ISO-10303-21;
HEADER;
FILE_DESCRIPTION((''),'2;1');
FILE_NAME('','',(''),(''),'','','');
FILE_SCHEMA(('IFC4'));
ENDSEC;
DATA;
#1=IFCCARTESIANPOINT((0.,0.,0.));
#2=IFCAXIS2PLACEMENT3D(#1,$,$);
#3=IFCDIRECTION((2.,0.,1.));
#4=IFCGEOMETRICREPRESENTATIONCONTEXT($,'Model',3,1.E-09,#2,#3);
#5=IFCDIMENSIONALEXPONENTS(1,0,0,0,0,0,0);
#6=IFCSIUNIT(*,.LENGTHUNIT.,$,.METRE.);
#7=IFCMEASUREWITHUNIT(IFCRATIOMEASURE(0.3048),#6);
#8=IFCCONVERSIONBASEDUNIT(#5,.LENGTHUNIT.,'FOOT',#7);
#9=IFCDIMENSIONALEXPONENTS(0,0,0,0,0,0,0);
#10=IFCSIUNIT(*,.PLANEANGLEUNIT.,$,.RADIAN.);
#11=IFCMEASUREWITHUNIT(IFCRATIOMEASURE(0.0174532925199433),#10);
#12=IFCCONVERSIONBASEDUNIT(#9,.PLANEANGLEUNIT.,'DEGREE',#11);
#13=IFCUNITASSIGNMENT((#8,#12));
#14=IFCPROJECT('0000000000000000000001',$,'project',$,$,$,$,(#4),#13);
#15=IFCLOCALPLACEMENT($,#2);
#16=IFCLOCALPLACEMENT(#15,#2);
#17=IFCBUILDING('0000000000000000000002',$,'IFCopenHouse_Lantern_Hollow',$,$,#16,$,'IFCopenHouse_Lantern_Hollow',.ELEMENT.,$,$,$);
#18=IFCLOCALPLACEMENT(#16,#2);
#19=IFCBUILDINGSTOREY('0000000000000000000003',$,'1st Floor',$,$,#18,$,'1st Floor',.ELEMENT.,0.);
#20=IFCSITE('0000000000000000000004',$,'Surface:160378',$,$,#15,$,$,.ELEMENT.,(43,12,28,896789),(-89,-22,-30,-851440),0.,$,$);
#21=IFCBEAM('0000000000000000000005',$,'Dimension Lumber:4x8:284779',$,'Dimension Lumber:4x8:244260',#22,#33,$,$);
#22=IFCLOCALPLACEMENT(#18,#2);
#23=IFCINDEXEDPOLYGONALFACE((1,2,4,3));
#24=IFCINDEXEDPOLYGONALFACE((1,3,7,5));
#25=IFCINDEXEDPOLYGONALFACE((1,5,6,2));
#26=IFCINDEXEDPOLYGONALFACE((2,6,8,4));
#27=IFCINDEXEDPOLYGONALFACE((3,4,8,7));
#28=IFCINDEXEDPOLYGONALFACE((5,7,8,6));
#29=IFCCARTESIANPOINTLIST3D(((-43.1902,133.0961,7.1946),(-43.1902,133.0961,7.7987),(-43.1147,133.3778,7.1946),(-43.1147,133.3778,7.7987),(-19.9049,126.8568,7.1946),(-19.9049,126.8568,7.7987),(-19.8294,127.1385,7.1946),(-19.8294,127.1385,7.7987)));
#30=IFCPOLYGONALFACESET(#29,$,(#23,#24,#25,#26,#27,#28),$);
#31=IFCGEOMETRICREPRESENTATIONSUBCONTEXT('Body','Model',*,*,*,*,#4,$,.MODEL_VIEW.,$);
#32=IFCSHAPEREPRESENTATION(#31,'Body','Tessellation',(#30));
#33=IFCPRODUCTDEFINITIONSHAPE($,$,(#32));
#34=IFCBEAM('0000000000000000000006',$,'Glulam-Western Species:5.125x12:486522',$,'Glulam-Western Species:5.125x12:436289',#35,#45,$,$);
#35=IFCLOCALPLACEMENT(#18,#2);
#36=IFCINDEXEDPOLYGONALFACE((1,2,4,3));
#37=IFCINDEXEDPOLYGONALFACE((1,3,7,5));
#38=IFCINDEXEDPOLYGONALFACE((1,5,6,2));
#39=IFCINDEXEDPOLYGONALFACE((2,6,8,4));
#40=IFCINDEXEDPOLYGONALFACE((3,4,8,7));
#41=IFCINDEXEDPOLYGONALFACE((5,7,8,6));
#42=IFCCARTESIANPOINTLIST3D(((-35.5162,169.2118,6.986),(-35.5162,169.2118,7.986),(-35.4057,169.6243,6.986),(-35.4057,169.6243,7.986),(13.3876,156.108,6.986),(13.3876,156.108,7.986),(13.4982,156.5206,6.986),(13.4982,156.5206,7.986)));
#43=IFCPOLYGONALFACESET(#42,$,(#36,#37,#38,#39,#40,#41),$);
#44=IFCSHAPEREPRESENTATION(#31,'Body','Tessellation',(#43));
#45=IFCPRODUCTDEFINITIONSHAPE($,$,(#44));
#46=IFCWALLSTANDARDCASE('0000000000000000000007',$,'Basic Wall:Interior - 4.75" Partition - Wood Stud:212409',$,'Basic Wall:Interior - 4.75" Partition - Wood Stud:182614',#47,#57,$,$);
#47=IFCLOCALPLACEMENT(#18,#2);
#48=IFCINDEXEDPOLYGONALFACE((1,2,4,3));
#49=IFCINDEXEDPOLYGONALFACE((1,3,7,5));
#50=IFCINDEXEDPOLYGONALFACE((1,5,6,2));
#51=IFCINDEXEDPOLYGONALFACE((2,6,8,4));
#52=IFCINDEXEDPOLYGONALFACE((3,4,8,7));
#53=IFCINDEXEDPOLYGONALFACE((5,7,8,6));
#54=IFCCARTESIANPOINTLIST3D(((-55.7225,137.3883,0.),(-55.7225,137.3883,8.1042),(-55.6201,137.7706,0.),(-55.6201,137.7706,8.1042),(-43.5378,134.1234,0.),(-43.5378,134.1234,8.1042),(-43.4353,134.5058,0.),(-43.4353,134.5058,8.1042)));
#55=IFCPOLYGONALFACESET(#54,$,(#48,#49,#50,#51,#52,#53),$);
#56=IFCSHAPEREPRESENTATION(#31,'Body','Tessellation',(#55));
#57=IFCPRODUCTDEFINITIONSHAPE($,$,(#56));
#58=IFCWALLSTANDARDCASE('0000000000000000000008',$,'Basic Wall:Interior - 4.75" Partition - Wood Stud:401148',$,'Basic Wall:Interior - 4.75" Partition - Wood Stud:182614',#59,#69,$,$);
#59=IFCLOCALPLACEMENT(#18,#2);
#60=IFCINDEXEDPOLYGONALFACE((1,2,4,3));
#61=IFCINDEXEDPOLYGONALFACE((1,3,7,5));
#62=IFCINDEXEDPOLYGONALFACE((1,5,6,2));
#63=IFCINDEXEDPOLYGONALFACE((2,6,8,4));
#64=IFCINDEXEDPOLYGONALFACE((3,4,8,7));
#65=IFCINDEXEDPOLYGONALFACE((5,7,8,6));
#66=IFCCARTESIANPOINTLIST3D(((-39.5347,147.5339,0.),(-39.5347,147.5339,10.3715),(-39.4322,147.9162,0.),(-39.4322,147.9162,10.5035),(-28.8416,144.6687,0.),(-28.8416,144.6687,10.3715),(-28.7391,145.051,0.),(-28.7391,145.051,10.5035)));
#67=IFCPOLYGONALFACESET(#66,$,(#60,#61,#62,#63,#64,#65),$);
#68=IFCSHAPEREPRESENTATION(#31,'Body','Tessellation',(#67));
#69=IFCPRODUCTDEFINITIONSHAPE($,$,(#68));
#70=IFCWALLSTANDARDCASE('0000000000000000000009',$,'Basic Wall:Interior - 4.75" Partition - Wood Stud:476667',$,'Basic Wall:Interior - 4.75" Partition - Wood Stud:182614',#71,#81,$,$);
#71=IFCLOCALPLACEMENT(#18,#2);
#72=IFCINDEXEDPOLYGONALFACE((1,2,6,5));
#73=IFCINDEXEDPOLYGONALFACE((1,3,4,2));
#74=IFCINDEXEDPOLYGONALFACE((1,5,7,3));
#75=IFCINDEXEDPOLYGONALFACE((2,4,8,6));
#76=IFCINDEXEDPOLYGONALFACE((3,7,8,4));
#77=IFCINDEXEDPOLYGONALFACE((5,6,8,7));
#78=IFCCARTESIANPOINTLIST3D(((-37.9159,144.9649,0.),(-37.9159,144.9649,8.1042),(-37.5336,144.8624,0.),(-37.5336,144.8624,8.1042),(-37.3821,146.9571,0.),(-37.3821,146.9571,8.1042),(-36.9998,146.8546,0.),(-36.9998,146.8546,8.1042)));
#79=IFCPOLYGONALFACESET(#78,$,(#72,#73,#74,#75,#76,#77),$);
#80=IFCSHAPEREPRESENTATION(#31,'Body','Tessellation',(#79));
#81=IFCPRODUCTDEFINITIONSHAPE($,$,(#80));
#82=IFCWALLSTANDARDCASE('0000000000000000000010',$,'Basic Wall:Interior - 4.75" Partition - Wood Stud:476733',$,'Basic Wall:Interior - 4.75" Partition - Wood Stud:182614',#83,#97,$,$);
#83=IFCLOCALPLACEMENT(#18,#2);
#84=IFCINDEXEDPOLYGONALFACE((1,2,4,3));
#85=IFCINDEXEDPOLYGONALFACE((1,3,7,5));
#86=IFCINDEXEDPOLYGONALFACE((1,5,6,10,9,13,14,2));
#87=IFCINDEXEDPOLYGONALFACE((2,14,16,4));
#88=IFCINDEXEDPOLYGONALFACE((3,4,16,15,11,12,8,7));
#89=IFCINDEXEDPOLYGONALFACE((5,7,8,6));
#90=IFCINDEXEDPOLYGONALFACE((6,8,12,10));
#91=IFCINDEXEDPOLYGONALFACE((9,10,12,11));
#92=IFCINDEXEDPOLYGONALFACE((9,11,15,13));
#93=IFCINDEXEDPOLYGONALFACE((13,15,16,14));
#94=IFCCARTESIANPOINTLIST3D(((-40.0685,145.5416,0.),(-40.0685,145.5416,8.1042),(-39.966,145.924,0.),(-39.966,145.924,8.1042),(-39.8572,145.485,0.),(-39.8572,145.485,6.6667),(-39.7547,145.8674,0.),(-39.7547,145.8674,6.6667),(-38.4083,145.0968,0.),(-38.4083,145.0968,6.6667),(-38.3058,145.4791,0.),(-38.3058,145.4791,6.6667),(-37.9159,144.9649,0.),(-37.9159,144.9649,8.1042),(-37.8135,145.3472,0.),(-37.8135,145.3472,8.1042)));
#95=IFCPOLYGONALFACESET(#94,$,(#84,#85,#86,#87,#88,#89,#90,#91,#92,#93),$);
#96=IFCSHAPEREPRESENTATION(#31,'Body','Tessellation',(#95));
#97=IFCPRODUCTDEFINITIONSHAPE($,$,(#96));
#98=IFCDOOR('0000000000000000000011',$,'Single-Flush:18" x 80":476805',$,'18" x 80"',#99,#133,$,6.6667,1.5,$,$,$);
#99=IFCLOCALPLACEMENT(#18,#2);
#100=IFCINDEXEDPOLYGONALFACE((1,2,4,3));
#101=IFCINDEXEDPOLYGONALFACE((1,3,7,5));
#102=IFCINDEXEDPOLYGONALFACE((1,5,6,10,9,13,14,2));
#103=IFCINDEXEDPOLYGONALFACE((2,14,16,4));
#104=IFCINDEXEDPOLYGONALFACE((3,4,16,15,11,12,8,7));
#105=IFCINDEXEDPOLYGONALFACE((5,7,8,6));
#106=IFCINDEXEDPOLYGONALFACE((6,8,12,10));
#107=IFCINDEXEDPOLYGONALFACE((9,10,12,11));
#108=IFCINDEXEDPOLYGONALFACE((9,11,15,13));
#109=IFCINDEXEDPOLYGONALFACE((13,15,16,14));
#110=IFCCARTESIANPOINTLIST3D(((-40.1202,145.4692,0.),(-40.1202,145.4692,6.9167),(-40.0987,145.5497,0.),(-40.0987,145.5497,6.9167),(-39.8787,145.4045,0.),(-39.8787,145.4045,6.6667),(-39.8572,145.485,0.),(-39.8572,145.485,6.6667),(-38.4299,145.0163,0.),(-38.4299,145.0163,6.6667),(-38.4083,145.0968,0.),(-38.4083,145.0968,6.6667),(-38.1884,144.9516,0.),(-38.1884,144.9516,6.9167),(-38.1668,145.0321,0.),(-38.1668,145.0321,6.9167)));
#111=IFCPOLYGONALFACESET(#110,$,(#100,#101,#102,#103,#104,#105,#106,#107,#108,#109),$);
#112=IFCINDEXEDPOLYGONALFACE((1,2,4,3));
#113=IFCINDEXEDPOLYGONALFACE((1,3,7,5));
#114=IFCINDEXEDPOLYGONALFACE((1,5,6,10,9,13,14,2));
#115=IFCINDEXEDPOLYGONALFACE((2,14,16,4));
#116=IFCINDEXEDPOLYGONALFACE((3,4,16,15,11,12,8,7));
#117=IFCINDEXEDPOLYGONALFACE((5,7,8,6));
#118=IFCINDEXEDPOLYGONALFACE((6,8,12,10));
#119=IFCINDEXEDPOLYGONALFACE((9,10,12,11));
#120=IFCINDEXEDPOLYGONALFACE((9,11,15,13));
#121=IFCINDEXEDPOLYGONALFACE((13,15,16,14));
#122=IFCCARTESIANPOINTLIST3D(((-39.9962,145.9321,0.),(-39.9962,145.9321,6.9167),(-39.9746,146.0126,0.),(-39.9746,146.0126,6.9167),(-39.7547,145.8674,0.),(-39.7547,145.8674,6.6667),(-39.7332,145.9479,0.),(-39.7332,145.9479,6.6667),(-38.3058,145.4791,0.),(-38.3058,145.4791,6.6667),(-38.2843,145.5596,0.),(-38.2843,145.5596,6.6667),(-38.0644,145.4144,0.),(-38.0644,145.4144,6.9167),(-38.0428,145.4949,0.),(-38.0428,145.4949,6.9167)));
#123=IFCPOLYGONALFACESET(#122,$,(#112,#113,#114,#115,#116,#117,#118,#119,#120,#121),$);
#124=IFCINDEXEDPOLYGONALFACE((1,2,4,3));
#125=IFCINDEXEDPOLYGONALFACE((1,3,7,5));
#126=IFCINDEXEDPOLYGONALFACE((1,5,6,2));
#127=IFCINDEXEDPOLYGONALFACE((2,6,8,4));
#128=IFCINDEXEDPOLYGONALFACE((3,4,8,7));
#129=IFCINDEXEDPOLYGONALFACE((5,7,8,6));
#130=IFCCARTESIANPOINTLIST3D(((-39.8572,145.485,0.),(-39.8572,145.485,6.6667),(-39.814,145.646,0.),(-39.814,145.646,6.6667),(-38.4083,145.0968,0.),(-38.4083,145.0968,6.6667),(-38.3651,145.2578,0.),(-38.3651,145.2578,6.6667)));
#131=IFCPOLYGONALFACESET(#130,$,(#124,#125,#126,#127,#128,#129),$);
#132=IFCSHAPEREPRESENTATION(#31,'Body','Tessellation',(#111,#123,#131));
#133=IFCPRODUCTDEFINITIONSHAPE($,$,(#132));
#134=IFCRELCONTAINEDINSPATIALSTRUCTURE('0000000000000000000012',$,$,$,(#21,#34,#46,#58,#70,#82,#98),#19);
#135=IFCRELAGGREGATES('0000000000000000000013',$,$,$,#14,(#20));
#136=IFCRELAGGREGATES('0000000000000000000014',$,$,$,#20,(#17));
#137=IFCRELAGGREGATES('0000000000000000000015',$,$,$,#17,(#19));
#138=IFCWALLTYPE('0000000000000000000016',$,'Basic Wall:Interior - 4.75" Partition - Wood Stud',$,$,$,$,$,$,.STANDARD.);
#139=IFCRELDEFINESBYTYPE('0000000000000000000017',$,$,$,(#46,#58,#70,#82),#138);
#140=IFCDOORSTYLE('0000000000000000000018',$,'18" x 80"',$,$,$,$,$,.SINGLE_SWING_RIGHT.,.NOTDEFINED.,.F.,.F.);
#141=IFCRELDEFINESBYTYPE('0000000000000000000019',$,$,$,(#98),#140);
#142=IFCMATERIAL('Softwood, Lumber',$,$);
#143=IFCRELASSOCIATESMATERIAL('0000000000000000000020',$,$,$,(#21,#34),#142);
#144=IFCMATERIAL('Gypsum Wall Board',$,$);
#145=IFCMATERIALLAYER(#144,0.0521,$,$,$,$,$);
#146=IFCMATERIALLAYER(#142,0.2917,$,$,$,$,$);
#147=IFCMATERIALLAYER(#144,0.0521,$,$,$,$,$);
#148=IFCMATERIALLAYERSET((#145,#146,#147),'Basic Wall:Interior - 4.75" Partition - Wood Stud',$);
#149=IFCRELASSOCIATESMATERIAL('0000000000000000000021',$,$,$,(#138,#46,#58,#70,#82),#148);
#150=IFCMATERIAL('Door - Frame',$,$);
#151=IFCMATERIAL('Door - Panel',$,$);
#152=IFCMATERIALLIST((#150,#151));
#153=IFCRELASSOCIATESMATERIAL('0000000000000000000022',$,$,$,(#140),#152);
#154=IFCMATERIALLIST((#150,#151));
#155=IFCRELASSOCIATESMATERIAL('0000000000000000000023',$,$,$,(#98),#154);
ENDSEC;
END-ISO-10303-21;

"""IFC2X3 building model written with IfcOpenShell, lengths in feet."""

from ifc_helpers import new_model, entity, si_unit, converted_unit, direction, frame, frame_2d, origin, place, context, subcontext, project, spatial, polyline, rectangle, outline, extrude, clip, bounded_halfspace, source, transform, mapped, material, material_list, layer, layer_set, layer_usage, type_object, type_shapes, element, fill, save


model = new_model("IFC2X3")

# Units and contexts
model_context = context("Model", 3, precision=1e-09, world=origin(), true_north=direction((2.0, 0.0, 1.0)))
body_context = subcontext(model_context, "Body", "Model", "MODEL_VIEW")
ifc_project = project(units=[converted_unit("LENGTHUNIT", "FOOT", entity("IfcRatioMeasure", 0.3048), si_unit("LENGTHUNIT", "METRE"), dimensions=[1, 0, 0, 0, 0, 0, 0]), converted_unit("PLANEANGLEUNIT", "DEGREE", entity("IfcRatioMeasure", 0.0174532925199433), si_unit("PLANEANGLEUNIT", "RADIAN"), dimensions=[0, 0, 0, 0, 0, 0, 0])], contexts=[model_context])

# Site, building, storey
site_placement = place(None, origin())
site = spatial("IfcSite", under=ifc_project, at=site_placement, Name="Surface:160378", CompositionType="ELEMENT", RefLatitude=(43, 12, 28, 896789), RefLongitude=(-89, -22, -30, -851440), RefElevation=0.0)
building_placement = place(site_placement, origin())
building = spatial("IfcBuilding", under=site, at=building_placement, Name="IFCopenHouse_Lantern_Hollow", LongName="IFCopenHouse_Lantern_Hollow", CompositionType="ELEMENT")
storey_placement = place(building_placement, origin())
storey = spatial("IfcBuildingStorey", under=building, at=storey_placement, Name="1st Floor", LongName="1st Floor", CompositionType="ELEMENT", Elevation=0.0)

# Beams
ifc_material_1 = material(Name="Softwood, Lumber")
beam_1_placement = place(storey_placement, frame((-43.1524, 133.237, 7.1946), z_axis=(0.0, 0.0, 1.0), x_axis=(0.965926, -0.258819, 0.0)))
element("IfcBeam", 1, at=beam_1_placement, inside=storey, material=ifc_material_1, Name="Dimension Lumber:4x8:284779", ObjectType="Dimension Lumber:4x8:244260", context=body_context, shape_type="SweptSolid", body=[
    extrude(rectangle(XDim=0.6042, YDim=0.2917, at=frame_2d((0.0, 0.0), x_axis=(1.0, 0.0))), frame((0.0, 0.0, 0.3021), z_axis=(1.0, 0.0, 0.0), x_axis=(0.0, 0.0, -1.0)), (0.0, 0.0, 1.0), 24.1067),
])
beam_2_placement = place(storey_placement, frame((-35.461, 169.418, 7.986), z_axis=(0.0, 0.0, 1.0), x_axis=(0.965926, -0.258819, 0.0)))
element("IfcBeam", 2, at=beam_2_placement, inside=storey, material=ifc_material_1, Name="Glulam-Western Species:5.125x12:486522", ObjectType="Glulam-Western Species:5.125x12:436289", context=body_context, shape_type="SweptSolid", body=[
    extrude(rectangle(XDim=1.0, YDim=0.4271, at=frame_2d((0.0, 0.0), x_axis=(1.0, 0.0))), frame((0.0, 0.0, -0.5), z_axis=(1.0, 0.0, 0.0), x_axis=(0.0, 0.0, -1.0)), (0.0, 0.0, 1.0), 50.629),
])

# Wall
ifc_material_2 = material(Name="Gypsum Wall Board")
ifc_layer_1 = layer(ifc_material_2, 0.0521)
ifc_layer_2 = layer(ifc_material_1, 0.2917)
ifc_layer_3 = layer(ifc_material_2, 0.0521)
ifc_layer_set = layer_set([ifc_layer_1, ifc_layer_2, ifc_layer_3], Name="Basic Wall:Interior - 4.75\" Partition - Wood Stud")
ifc_layer_usage_1 = layer_usage(ifc_layer_set, "AXIS2", "NEGATIVE", 0.1979)
wall_type = type_object("IfcWallType", Name="Basic Wall:Interior - 4.75\" Partition - Wood Stud", PredefinedType="STANDARD", material=ifc_layer_set)
wall_1_placement = place(storey_placement, frame((-43.4865, 134.3146, 0.0), z_axis=(0.0, 0.0, 1.0), x_axis=(-0.965926, 0.258819, 0.0)))
element("IfcWallStandardCase", 3, at=wall_1_placement, inside=storey, type_object=wall_type, material=ifc_layer_usage_1, Name="Basic Wall:Interior - 4.75\" Partition - Wood Stud:212409", ObjectType="Basic Wall:Interior - 4.75\" Partition - Wood Stud:182614", context=body_context, shape_type="SweptSolid", body=[
    extrude(rectangle(XDim=12.6146, YDim=0.3958, at=frame_2d((6.3073, 0.0), x_axis=(-1.0, 0.0))), origin(), (0.0, 0.0, 1.0), 8.1042),
])

# Shared definitions
ifc_material_3 = material(Name="Door - Frame")
ifc_material_4 = material(Name="Door - Panel")

# Walls
ifc_layer_usage_2 = layer_usage(ifc_layer_set, "AXIS2", "NEGATIVE", 0.1979)
wall_2_placement = place(storey_placement, frame((-28.7903, 144.8598, 0.0), z_axis=(0.0, 0.0, 1.0), x_axis=(-0.965926, 0.258819, 0.0)))
element("IfcWallStandardCase", 4, at=wall_2_placement, inside=storey, type_object=wall_type, material=ifc_layer_usage_2, Name="Basic Wall:Interior - 4.75\" Partition - Wood Stud:401148", ObjectType="Basic Wall:Interior - 4.75\" Partition - Wood Stud:182614", context=body_context, shape_type="Clipping", body=[
    clip(extrude(rectangle(XDim=11.0703, YDim=0.3958, at=frame_2d((5.5352, 0.0), x_axis=(-1.0, 0.0))), origin(), (0.0, 0.0, 1.0), 10.5035), bounded_halfspace(frame((0.0, -0.1979, 10.5035), z_axis=(0.0, 0.316228, 0.948683), x_axis=(-1.0, 0.0, 0.0)), False, frame((0.0, -0.1979, 10.5035)), polyline([(0.0, 0.0), (11.0703, 0.0), (11.0703, 0.3958), (0.0, 0.3958), (0.0, 0.0)]))),
])
ifc_layer_usage_3 = layer_usage(ifc_layer_set, "AXIS2", "POSITIVE", -0.1979)
wall_3_placement = place(storey_placement, frame((-37.1909, 146.9059, 0.0), z_axis=(0.0, 0.0, 1.0), x_axis=(-0.258819, -0.965926, 0.0)))
element("IfcWallStandardCase", 5, at=wall_3_placement, inside=storey, type_object=wall_type, material=ifc_layer_usage_3, Name="Basic Wall:Interior - 4.75\" Partition - Wood Stud:476667", ObjectType="Basic Wall:Interior - 4.75\" Partition - Wood Stud:182614", context=body_context, shape_type="SweptSolid", body=[
    extrude(rectangle(XDim=2.0625, YDim=0.3958, at=frame_2d((1.0313, 0.0), x_axis=(-1.0, 0.0))), origin(), (0.0, 0.0, 1.0), 8.1042),
])

# Wall, opening, door
ifc_layer_usage_4 = layer_usage(ifc_layer_set, "AXIS2", "NEGATIVE", 0.1979)
wall_4_placement = place(storey_placement, frame((-37.8647, 145.156, 0.0), z_axis=(0.0, 0.0, 1.0), x_axis=(-0.965926, 0.258819, 0.0)))
wall_4 = element("IfcWallStandardCase", 6, at=wall_4_placement, inside=storey, type_object=wall_type, material=ifc_layer_usage_4, Name="Basic Wall:Interior - 4.75\" Partition - Wood Stud:476733", ObjectType="Basic Wall:Interior - 4.75\" Partition - Wood Stud:182614", context=body_context, shape_type="SweptSolid", body=[
    extrude(rectangle(XDim=2.2285, YDim=0.3958, at=frame_2d((1.1142, 0.0), x_axis=(-1.0, 0.0))), origin(), (0.0, 0.0, 1.0), 8.1042),
])
opening_1_placement = place(wall_4_placement, frame((0.5097, -0.1979, 0.0)))
opening_1 = element("IfcOpeningElement", 7, at=opening_1_placement, cuts=wall_4, ObjectType="Opening", context=body_context, shape_type="SweptSolid", body=[
    extrude(rectangle(XDim=1.5, YDim=6.6667, at=frame_2d((3.3333, 0.75), x_axis=(0.0, 1.0))), frame((0.0, 0.0, 0.0), z_axis=(0.0, 1.0, 0.0), x_axis=(0.0, 0.0, 1.0)), (0.0, 0.0, 1.0), 0.3958),
])
ifc_material_list_1 = material_list([ifc_material_3, ifc_material_4])
ifc_material_list_2 = material_list([ifc_material_3, ifc_material_4])
door_style_1 = type_object("IfcDoorStyle", Name="18\" x 80\"", ConstructionType="NOTDEFINED", OperationType="SINGLE_SWING_RIGHT", ParameterTakesPrecedence=False, Sizeable=False, material=ifc_material_list_2)
shared_shape_1 = source(origin(), body_context, "Body", "SweptSolid", [
    extrude(outline(polyline([(-1.0, -3.5208), (1.0, -3.5208), (1.0, 3.3958), (0.75, 3.3958), (0.75, -3.2708), (-0.75, -3.2708), (-0.75, 3.3958), (-1.0, 3.3958), (-1.0, -3.5208)])), frame((0.75, 0.3958, 3.3958), z_axis=(0.0, 1.0, 0.0), x_axis=(1.0, 0.0, 0.0)), (0.0, 0.0, 1.0), 0.0833),
    extrude(outline(polyline([(-3.5208, -1.0), (3.3958, -1.0), (3.3958, -0.75), (-3.2708, -0.75), (-3.2708, 0.75), (3.3958, 0.75), (3.3958, 1.0), (-3.5208, 1.0), (-3.5208, -1.0)])), frame((0.75, -0.0833, 3.3958), z_axis=(0.0, 1.0, 0.0), x_axis=(0.0, 0.0, -1.0)), (0.0, 0.0, 1.0), 0.0833),
    extrude(rectangle(XDim=0.1667, YDim=1.5, at=frame_2d((0.0, 0.0), x_axis=(1.0, 0.0))), frame((0.75, 0.3125, 0.0), z_axis=(0.0, 0.0, 1.0), x_axis=(0.0, 1.0, 0.0)), (0.0, 0.0, 1.0), 6.6667),
])
type_shapes(door_style_1, [shared_shape_1])
door_1_placement = place(opening_1_placement, origin())
door_1 = element("IfcDoor", 8, at=door_1_placement, inside=storey, type_object=door_style_1, material=ifc_material_list_1, Name="Single-Flush:18\" x 80\":476805", ObjectType="18\" x 80\"", OverallHeight=6.6667, OverallWidth=1.5, context=body_context, shape_type="MappedRepresentation", body=[
    mapped(shared_shape_1, transform((0.0, 0.0, 0.0), scale=1.0)),
])
fill(opening_1, door_1)

save(model, "model.ifc")
